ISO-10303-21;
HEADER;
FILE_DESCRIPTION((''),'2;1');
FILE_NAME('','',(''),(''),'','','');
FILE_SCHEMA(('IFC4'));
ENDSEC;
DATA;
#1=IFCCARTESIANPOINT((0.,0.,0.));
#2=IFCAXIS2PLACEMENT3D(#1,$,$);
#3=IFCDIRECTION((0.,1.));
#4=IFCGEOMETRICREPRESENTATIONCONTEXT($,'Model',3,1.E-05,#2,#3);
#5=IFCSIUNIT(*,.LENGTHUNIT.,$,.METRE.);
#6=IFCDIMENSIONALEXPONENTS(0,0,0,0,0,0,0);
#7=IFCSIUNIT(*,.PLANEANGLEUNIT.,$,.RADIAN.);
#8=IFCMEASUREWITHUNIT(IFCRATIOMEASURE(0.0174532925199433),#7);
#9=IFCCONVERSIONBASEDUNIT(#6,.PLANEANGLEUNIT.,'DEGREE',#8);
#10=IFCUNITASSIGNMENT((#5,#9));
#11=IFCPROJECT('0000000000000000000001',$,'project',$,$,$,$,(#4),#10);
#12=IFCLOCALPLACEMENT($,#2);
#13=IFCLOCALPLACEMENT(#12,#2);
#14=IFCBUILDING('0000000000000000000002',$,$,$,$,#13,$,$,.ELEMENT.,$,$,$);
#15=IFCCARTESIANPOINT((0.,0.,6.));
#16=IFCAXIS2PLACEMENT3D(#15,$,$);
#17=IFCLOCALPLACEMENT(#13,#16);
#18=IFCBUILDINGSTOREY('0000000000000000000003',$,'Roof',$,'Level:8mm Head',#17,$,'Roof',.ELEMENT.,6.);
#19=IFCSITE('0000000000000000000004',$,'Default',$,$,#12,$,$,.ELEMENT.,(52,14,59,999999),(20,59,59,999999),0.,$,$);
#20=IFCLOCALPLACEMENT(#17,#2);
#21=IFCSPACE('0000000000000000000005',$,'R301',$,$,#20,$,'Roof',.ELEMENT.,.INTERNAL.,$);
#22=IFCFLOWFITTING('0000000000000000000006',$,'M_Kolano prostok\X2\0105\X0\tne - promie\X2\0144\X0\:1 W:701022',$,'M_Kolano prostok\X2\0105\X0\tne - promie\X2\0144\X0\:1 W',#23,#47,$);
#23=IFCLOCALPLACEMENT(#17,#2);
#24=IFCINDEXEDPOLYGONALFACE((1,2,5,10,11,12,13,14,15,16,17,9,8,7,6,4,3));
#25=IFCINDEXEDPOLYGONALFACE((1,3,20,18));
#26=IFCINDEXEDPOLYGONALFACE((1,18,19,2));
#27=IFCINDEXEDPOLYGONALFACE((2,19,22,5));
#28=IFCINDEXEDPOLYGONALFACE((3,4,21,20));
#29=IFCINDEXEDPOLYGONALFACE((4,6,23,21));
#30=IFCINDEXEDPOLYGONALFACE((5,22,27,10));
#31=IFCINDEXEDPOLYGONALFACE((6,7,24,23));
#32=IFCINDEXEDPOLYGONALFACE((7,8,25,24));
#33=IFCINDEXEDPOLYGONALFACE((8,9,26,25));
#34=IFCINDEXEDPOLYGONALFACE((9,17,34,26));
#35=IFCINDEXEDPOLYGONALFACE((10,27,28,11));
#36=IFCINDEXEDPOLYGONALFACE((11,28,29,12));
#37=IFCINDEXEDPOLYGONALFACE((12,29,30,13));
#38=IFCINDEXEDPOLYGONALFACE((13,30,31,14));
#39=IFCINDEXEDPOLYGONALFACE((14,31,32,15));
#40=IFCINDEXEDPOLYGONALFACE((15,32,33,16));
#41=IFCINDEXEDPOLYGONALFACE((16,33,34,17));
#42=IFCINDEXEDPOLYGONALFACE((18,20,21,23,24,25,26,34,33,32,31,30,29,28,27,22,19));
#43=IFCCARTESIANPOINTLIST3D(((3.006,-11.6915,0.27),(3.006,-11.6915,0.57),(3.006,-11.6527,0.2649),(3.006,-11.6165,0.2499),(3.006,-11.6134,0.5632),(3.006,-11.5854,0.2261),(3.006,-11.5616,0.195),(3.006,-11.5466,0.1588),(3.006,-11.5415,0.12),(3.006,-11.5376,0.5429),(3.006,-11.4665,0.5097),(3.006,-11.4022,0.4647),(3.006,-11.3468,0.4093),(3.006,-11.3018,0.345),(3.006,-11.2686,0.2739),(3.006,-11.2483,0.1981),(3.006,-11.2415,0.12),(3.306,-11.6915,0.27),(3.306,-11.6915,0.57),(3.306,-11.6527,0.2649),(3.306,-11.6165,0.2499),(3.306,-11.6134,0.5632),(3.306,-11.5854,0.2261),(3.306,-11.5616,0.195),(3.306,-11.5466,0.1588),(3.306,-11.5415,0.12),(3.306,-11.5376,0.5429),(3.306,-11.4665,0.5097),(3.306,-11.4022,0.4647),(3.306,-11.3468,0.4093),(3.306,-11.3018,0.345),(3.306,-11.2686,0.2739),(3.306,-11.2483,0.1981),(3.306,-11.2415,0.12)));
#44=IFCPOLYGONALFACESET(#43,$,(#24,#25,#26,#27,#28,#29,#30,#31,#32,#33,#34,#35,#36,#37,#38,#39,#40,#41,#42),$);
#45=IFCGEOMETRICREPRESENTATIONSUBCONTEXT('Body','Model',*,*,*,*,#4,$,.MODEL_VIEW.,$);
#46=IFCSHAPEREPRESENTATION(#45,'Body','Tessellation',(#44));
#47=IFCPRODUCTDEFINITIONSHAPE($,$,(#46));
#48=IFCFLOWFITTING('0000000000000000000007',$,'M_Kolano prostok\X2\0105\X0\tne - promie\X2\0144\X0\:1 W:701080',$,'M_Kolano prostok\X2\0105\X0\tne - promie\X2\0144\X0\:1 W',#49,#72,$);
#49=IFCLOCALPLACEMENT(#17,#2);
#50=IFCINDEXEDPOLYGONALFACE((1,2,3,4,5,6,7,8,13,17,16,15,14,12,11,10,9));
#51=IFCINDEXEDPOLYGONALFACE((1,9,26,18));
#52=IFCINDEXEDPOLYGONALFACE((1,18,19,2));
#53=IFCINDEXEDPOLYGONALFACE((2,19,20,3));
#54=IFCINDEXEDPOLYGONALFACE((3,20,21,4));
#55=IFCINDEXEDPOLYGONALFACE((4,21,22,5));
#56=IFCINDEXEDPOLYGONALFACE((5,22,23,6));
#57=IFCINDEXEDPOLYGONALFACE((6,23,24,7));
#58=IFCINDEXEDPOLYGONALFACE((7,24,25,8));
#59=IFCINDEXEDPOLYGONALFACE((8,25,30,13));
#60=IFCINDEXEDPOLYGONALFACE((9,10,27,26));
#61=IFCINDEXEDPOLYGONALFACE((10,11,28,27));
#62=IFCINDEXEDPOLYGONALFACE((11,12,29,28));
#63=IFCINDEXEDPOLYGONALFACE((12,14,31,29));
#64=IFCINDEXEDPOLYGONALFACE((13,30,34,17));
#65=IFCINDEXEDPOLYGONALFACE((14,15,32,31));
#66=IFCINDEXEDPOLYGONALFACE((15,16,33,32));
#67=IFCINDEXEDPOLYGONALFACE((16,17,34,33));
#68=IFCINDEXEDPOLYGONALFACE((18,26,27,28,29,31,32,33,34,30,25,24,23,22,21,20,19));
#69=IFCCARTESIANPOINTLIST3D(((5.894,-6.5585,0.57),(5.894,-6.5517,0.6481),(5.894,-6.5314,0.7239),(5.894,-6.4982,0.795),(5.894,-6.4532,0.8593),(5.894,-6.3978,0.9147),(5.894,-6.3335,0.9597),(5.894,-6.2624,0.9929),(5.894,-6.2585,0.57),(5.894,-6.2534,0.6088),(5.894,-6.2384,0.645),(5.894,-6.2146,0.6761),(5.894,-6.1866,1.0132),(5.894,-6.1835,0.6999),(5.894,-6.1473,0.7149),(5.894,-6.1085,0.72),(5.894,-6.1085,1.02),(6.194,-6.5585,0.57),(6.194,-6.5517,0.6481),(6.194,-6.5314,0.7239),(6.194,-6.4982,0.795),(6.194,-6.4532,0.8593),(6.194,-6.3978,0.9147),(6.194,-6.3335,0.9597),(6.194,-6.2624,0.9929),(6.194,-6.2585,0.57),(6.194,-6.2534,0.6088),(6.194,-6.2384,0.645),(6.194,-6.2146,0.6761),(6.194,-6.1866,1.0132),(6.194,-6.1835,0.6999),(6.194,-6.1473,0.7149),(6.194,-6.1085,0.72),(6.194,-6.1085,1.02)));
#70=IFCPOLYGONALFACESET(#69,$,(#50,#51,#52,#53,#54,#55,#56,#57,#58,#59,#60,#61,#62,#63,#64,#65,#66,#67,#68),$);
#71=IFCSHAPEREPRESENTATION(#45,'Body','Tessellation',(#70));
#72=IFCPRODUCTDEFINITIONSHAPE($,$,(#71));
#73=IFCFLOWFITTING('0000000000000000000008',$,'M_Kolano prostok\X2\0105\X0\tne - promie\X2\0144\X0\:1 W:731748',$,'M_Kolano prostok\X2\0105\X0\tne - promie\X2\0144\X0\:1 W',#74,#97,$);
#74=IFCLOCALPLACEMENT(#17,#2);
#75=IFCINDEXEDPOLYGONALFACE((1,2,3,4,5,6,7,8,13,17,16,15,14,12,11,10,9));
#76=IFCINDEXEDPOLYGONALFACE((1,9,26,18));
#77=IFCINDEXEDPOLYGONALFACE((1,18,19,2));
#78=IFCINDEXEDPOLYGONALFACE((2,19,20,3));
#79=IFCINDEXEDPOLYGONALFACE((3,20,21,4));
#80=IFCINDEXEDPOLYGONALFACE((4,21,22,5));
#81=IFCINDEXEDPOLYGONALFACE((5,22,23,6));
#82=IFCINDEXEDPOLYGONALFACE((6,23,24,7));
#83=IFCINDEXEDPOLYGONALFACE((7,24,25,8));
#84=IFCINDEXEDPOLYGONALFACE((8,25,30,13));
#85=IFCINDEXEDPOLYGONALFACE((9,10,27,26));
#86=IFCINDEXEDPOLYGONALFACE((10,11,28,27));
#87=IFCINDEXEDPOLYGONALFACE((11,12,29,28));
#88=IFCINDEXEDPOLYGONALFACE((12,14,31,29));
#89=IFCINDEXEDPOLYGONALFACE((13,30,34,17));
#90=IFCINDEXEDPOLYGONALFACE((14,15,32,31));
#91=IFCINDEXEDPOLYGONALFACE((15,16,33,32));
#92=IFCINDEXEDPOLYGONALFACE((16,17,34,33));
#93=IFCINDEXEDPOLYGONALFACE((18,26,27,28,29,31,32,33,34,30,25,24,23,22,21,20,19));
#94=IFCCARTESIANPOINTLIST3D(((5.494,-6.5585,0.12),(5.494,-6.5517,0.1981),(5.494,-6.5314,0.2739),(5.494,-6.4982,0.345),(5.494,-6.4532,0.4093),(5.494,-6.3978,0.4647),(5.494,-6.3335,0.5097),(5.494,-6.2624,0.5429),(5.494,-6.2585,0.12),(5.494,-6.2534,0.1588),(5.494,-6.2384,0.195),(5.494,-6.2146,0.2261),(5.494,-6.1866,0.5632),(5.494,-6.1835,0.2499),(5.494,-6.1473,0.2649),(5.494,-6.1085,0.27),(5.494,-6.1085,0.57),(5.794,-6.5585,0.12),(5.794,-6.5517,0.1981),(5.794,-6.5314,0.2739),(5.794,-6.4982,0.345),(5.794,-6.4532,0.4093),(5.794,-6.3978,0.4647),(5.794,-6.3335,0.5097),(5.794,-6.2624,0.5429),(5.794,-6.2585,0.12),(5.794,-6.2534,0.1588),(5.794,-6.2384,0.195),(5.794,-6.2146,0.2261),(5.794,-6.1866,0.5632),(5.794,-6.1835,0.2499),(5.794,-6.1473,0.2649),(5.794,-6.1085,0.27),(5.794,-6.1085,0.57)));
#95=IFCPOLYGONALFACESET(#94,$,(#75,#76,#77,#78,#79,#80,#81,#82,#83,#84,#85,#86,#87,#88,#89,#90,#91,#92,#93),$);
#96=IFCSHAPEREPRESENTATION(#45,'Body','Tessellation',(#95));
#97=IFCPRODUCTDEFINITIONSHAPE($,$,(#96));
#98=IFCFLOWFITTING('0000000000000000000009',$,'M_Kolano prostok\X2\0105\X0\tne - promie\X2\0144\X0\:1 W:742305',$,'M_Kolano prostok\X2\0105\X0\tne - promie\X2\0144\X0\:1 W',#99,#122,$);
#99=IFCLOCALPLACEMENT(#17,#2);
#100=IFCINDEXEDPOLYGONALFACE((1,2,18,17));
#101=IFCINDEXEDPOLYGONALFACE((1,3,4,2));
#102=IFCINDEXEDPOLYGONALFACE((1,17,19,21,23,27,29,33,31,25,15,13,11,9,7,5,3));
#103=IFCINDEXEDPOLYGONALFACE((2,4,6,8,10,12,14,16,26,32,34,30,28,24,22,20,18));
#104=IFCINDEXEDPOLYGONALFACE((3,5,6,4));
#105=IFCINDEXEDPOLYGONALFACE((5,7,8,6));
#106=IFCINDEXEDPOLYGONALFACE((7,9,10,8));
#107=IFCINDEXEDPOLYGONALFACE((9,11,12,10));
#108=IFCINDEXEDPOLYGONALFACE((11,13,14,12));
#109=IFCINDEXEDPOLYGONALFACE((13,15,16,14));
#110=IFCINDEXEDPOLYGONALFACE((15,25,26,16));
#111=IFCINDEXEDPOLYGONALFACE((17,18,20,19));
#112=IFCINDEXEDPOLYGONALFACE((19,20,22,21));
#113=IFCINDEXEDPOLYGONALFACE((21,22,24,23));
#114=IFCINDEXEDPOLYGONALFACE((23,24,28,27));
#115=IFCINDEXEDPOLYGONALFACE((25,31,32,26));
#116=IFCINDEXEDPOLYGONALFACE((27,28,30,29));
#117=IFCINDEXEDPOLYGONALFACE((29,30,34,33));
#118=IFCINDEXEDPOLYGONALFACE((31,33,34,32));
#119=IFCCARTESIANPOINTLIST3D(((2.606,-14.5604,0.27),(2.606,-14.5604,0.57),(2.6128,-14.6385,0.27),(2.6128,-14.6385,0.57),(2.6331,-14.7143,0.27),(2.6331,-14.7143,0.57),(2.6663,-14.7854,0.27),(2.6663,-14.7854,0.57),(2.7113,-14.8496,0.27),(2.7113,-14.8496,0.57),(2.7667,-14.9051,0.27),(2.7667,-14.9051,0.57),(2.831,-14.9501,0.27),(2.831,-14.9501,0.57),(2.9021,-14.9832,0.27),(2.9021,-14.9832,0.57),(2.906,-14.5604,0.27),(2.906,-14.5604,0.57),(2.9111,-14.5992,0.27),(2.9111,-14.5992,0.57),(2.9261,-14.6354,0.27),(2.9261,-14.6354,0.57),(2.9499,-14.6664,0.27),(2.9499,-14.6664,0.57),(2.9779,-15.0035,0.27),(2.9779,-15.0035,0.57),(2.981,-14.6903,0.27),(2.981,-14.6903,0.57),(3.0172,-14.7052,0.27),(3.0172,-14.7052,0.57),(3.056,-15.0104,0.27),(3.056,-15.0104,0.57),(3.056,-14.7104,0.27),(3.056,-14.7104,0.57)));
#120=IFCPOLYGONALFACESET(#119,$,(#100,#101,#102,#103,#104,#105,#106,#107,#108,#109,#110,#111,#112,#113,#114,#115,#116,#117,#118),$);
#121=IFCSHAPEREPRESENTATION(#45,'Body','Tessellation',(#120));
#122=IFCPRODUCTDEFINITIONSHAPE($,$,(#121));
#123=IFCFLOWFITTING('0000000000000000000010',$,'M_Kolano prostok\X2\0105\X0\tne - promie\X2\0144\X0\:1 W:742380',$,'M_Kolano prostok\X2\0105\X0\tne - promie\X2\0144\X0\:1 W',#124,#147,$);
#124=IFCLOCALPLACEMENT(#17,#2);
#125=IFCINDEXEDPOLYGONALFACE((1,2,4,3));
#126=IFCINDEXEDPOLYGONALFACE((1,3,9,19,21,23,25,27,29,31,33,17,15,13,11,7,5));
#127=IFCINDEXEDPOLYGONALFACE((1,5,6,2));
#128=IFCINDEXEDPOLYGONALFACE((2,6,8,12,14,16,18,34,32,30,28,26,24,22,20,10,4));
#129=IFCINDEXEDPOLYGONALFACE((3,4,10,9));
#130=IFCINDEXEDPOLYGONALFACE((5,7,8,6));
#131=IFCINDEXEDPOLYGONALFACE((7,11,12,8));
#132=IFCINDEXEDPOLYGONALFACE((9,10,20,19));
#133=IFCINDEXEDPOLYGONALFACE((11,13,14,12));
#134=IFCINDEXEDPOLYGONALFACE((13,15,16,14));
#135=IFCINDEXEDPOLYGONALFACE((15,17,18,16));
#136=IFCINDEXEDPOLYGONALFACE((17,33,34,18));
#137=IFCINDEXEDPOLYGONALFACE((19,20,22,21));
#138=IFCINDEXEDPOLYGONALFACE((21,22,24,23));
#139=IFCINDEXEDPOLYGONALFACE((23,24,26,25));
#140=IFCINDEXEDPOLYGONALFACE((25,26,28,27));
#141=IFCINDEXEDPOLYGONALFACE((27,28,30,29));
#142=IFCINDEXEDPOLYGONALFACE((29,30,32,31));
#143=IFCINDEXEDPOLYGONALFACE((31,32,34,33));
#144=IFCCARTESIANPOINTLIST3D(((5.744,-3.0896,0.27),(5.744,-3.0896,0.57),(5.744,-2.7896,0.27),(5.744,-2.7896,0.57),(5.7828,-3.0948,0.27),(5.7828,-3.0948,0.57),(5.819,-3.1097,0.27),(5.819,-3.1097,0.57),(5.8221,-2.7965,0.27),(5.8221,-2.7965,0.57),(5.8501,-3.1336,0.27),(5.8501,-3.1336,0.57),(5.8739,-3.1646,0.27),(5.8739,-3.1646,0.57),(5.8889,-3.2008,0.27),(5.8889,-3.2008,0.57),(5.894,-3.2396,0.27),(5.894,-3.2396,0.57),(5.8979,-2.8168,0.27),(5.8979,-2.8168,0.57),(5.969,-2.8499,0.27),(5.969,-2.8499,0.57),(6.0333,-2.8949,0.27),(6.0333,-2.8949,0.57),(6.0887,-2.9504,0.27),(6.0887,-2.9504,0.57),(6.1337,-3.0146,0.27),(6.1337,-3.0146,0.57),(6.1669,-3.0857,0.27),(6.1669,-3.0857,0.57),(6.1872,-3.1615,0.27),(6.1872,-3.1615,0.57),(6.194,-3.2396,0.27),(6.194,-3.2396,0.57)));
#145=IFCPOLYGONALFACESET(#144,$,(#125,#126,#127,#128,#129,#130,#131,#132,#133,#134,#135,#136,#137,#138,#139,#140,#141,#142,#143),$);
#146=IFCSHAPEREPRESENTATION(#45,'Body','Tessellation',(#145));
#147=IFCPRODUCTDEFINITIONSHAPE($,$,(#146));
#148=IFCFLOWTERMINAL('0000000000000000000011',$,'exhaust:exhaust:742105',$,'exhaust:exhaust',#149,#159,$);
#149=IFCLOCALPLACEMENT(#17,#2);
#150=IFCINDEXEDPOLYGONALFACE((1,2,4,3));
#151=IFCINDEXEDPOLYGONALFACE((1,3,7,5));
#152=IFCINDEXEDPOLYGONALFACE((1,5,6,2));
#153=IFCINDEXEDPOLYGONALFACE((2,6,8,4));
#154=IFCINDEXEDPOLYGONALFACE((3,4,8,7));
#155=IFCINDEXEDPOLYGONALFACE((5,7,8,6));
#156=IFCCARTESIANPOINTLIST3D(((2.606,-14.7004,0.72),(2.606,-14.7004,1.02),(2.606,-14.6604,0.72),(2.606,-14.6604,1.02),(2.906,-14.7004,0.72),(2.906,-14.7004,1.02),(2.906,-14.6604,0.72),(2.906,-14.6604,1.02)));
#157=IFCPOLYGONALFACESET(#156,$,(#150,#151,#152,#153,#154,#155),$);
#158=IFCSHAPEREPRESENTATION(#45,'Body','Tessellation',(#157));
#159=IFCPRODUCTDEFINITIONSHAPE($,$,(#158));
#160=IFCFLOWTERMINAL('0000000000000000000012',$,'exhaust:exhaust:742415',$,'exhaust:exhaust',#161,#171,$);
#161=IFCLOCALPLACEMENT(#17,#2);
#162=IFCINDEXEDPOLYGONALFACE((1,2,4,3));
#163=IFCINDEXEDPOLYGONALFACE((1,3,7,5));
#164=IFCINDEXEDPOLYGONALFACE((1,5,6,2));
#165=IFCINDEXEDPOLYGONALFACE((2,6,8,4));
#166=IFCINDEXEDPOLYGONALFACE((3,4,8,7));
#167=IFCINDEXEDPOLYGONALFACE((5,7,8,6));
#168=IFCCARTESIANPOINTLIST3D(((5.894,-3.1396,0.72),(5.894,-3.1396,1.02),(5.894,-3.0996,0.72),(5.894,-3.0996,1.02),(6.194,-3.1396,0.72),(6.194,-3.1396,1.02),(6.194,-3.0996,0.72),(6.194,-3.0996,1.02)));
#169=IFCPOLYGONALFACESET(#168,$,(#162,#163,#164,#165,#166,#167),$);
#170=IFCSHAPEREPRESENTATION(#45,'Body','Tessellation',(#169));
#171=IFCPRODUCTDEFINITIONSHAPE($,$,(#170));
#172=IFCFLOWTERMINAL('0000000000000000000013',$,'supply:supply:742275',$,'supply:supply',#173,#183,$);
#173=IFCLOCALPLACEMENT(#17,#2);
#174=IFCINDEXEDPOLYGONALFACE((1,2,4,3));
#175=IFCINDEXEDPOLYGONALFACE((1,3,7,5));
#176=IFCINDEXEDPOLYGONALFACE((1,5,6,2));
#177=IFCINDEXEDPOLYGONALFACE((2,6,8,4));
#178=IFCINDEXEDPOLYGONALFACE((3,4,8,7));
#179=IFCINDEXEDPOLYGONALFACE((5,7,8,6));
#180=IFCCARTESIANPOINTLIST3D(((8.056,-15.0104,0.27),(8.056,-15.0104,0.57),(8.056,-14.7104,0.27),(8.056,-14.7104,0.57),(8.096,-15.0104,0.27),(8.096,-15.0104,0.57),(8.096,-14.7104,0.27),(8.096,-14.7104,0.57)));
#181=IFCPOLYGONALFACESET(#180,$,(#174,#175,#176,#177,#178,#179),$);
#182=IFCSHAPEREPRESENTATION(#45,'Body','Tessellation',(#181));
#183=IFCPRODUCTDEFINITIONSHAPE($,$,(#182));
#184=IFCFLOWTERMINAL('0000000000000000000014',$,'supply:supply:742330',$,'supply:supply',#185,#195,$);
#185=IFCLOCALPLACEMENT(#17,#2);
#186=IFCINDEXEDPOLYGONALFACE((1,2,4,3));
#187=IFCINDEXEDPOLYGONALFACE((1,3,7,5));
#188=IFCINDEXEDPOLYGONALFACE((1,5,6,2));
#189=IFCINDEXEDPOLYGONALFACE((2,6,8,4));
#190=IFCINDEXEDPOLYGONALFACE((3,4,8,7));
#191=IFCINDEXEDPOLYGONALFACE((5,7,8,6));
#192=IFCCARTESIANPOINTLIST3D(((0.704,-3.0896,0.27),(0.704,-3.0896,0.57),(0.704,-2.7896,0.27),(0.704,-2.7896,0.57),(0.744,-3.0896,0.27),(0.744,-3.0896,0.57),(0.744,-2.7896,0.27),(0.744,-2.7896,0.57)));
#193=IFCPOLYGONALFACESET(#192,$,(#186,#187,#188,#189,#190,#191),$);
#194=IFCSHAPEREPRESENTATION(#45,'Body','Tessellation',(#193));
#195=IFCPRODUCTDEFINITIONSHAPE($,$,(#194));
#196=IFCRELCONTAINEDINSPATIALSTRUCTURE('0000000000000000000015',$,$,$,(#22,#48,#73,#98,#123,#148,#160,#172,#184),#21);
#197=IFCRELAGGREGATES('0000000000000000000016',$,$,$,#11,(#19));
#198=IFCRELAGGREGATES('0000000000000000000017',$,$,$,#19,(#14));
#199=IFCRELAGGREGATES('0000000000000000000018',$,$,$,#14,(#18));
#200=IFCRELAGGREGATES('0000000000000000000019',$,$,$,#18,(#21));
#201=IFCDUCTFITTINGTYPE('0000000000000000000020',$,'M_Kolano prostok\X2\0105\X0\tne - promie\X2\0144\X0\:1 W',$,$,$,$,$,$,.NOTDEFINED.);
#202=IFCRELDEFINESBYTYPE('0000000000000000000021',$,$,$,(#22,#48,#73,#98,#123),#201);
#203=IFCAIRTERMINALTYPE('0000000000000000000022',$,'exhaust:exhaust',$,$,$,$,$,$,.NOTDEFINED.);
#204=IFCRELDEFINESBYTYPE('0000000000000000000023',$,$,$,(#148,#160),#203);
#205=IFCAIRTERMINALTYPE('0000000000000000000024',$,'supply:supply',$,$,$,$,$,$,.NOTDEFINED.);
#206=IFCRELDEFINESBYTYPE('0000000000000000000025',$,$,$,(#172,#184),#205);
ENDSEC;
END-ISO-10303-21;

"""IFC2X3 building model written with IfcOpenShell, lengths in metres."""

from ifc_helpers import new_model, entity, si_unit, converted_unit, direction, frame, frame_2d, origin, origin_2d_with_axis, place, context, subcontext, project, spatial, polyline, circle_curve, parameter, trimmed, segment, composite_curve, rectangle, outline, extrude, source, transform, mapped, type_object, type_shapes, element, save


model = new_model("IFC2X3")

# Units and contexts
model_context = context("Model", 3, precision=1e-05, world=origin(), true_north=direction((0.0, 1.0)))
body_context = subcontext(model_context, "Body", "Model", "MODEL_VIEW")
ifc_project = project(units=[si_unit("LENGTHUNIT", "METRE"), converted_unit("PLANEANGLEUNIT", "DEGREE", entity("IfcRatioMeasure", 0.0174532925199433), si_unit("PLANEANGLEUNIT", "RADIAN"), dimensions=[0, 0, 0, 0, 0, 0, 0])], contexts=[model_context])

# Site, building, storey
site_placement = place(None, origin())
site = spatial("IfcSite", under=ifc_project, at=site_placement, Name="Default", CompositionType="ELEMENT", RefLatitude=(52, 14, 59, 999999), RefLongitude=(20, 59, 59, 999999), RefElevation=0.0)
building_placement = place(site_placement, origin())
building = spatial("IfcBuilding", under=site, at=building_placement, CompositionType="ELEMENT")
storey_placement = place(building_placement, frame((0.0, 0.0, 6.0)))
storey = spatial("IfcBuildingStorey", under=building, at=storey_placement, Name="Roof", ObjectType="Level:8mm Head", LongName="Roof", CompositionType="ELEMENT", Elevation=6.0)

# Shared definitions
space_placement = place(storey_placement, origin())
space = spatial("IfcSpace", under=storey, at=space_placement, Name="R301", LongName="Roof", CompositionType="ELEMENT", InteriorOrExteriorSpace="INTERNAL")

# Flow fittings
duct_fitting_type_1 = type_object("IfcDuctFittingType", Name="M_Kolano prostokątne - promień:1 W", PredefinedType="NOTDEFINED")
shared_shape_1 = source(origin(), body_context, "Body", "SweptSolid", [
    extrude(outline(composite_curve([segment(polyline([(-0.3, -0.15), (0.0, -0.15)]), True, "CONTINUOUS"), segment(trimmed(circle_curve(frame_2d((0.15, -0.15), x_axis=(0.0, 1.0)), 0.15), [parameter(0.0)], [parameter(90.0)], True, "PARAMETER"), False, "CONTINUOUS"), segment(polyline([(0.15, 0.0), (0.15, 0.3)]), True, "CONTINUOUS"), segment(trimmed(circle_curve(frame_2d((0.15, -0.15), x_axis=(0.0, 1.0)), 0.45), [parameter(0.0)], [parameter(90.0)], True, "PARAMETER"), True, "CONTINUOUS")], self_intersect=False)), frame((-0.15, 0.15, -0.15), z_axis=(0.0, 0.0, 1.0), x_axis=(-1.0, 0.0, 0.0)), (0.0, 0.0, 1.0), 0.3),
])
type_shapes(duct_fitting_type_1, [shared_shape_1])
for number, where, z_axis, x_axis, name in (
    (1, (3.156, -11.3915, 0.42), (1.0, 0.0, 0.0), (0.0, 0.0, 1.0), "M_Kolano prostokątne - promień:1 W:701022"),
    (2, (6.044, -6.4085, 0.87), (-1.0, 0.0, 0.0), (0.0, 0.0, 1.0), "M_Kolano prostokątne - promień:1 W:701080"),
    (3, (5.644, -6.4085, 0.42), (-1.0, 0.0, 0.0), (0.0, 0.0, 1.0), "M_Kolano prostokątne - promień:1 W:731748"),
    (4, (2.756, -14.8604, 0.42), (0.0, 0.0, 1.0), (0.0, -1.0, 0.0), "M_Kolano prostokątne - promień:1 W:742305"),
    (5, (6.044, -2.9396, 0.42), (0.0, 0.0, 1.0), (0.0, 1.0, 0.0), "M_Kolano prostokątne - promień:1 W:742380"),
):
    element("IfcFlowFitting", number, at=place(space_placement, frame(where, z_axis=z_axis, x_axis=x_axis)), inside=space, type_object=duct_fitting_type_1, Name=name, ObjectType="M_Kolano prostokątne - promień:1 W", context=body_context, shape_type="MappedRepresentation", body=[
        mapped(shared_shape_1, transform((0.0, 0.0, 0.0), scale=1.0)),
    ])

# Flow terminals
air_terminal_type_1 = type_object("IfcAirTerminalType", Name="exhaust:exhaust", PredefinedType="NOTDEFINED")
shared_shape_2 = source(origin(), body_context, "Body", "SweptSolid", [
    extrude(rectangle(XDim=0.3, YDim=0.3, at=origin_2d_with_axis()), frame((0.0, 0.0, 0.0), z_axis=(0.0, 0.0, 1.0), x_axis=(-1.0, 0.0, 0.0)), (0.0, 0.0, 1.0), 0.04),
])
type_shapes(air_terminal_type_1, [shared_shape_2])
for number, where, z_axis, x_axis, name in (
    (6, (2.756, -14.6604, 0.87), (0.0, -1.0, 0.0), (0.0, 0.0, -1.0), "exhaust:exhaust:742105"),
    (7, (6.044, -3.1396, 0.87), (0.0, 1.0, 0.0), (0.0, 0.0, 1.0), "exhaust:exhaust:742415"),
):
    element("IfcFlowTerminal", number, at=place(space_placement, frame(where, z_axis=z_axis, x_axis=x_axis)), inside=space, type_object=air_terminal_type_1, Name=name, ObjectType="exhaust:exhaust", context=body_context, shape_type="MappedRepresentation", body=[
        mapped(shared_shape_2, transform((0.0, 0.0, 0.0), scale=1.0)),
    ])
air_terminal_type_2 = type_object("IfcAirTerminalType", Name="supply:supply", PredefinedType="NOTDEFINED")
shared_shape_3 = source(origin(), body_context, "Body", "SweptSolid", [
    extrude(rectangle(XDim=0.3, YDim=0.3, at=origin_2d_with_axis()), frame((0.0, 0.0, 0.0), z_axis=(0.0, 0.0, 1.0), x_axis=(-1.0, 0.0, 0.0)), (0.0, 0.0, 1.0), 0.04),
])
type_shapes(air_terminal_type_2, [shared_shape_3])
for number, where, z_axis, x_axis, name in (
    (8, (8.056, -14.8604, 0.42), (1.0, 0.0, 0.0), (0.0, 1.0, 0.0), "supply:supply:742275"),
    (9, (0.744, -2.9396, 0.42), (-1.0, 0.0, 0.0), (0.0, -1.0, 0.0), "supply:supply:742330"),
):
    element("IfcFlowTerminal", number, at=place(space_placement, frame(where, z_axis=z_axis, x_axis=x_axis)), inside=space, type_object=air_terminal_type_2, Name=name, ObjectType="supply:supply", context=body_context, shape_type="MappedRepresentation", body=[
        mapped(shared_shape_3, transform((0.0, 0.0, 0.0), scale=1.0)),
    ])

save(model, "model.ifc")
